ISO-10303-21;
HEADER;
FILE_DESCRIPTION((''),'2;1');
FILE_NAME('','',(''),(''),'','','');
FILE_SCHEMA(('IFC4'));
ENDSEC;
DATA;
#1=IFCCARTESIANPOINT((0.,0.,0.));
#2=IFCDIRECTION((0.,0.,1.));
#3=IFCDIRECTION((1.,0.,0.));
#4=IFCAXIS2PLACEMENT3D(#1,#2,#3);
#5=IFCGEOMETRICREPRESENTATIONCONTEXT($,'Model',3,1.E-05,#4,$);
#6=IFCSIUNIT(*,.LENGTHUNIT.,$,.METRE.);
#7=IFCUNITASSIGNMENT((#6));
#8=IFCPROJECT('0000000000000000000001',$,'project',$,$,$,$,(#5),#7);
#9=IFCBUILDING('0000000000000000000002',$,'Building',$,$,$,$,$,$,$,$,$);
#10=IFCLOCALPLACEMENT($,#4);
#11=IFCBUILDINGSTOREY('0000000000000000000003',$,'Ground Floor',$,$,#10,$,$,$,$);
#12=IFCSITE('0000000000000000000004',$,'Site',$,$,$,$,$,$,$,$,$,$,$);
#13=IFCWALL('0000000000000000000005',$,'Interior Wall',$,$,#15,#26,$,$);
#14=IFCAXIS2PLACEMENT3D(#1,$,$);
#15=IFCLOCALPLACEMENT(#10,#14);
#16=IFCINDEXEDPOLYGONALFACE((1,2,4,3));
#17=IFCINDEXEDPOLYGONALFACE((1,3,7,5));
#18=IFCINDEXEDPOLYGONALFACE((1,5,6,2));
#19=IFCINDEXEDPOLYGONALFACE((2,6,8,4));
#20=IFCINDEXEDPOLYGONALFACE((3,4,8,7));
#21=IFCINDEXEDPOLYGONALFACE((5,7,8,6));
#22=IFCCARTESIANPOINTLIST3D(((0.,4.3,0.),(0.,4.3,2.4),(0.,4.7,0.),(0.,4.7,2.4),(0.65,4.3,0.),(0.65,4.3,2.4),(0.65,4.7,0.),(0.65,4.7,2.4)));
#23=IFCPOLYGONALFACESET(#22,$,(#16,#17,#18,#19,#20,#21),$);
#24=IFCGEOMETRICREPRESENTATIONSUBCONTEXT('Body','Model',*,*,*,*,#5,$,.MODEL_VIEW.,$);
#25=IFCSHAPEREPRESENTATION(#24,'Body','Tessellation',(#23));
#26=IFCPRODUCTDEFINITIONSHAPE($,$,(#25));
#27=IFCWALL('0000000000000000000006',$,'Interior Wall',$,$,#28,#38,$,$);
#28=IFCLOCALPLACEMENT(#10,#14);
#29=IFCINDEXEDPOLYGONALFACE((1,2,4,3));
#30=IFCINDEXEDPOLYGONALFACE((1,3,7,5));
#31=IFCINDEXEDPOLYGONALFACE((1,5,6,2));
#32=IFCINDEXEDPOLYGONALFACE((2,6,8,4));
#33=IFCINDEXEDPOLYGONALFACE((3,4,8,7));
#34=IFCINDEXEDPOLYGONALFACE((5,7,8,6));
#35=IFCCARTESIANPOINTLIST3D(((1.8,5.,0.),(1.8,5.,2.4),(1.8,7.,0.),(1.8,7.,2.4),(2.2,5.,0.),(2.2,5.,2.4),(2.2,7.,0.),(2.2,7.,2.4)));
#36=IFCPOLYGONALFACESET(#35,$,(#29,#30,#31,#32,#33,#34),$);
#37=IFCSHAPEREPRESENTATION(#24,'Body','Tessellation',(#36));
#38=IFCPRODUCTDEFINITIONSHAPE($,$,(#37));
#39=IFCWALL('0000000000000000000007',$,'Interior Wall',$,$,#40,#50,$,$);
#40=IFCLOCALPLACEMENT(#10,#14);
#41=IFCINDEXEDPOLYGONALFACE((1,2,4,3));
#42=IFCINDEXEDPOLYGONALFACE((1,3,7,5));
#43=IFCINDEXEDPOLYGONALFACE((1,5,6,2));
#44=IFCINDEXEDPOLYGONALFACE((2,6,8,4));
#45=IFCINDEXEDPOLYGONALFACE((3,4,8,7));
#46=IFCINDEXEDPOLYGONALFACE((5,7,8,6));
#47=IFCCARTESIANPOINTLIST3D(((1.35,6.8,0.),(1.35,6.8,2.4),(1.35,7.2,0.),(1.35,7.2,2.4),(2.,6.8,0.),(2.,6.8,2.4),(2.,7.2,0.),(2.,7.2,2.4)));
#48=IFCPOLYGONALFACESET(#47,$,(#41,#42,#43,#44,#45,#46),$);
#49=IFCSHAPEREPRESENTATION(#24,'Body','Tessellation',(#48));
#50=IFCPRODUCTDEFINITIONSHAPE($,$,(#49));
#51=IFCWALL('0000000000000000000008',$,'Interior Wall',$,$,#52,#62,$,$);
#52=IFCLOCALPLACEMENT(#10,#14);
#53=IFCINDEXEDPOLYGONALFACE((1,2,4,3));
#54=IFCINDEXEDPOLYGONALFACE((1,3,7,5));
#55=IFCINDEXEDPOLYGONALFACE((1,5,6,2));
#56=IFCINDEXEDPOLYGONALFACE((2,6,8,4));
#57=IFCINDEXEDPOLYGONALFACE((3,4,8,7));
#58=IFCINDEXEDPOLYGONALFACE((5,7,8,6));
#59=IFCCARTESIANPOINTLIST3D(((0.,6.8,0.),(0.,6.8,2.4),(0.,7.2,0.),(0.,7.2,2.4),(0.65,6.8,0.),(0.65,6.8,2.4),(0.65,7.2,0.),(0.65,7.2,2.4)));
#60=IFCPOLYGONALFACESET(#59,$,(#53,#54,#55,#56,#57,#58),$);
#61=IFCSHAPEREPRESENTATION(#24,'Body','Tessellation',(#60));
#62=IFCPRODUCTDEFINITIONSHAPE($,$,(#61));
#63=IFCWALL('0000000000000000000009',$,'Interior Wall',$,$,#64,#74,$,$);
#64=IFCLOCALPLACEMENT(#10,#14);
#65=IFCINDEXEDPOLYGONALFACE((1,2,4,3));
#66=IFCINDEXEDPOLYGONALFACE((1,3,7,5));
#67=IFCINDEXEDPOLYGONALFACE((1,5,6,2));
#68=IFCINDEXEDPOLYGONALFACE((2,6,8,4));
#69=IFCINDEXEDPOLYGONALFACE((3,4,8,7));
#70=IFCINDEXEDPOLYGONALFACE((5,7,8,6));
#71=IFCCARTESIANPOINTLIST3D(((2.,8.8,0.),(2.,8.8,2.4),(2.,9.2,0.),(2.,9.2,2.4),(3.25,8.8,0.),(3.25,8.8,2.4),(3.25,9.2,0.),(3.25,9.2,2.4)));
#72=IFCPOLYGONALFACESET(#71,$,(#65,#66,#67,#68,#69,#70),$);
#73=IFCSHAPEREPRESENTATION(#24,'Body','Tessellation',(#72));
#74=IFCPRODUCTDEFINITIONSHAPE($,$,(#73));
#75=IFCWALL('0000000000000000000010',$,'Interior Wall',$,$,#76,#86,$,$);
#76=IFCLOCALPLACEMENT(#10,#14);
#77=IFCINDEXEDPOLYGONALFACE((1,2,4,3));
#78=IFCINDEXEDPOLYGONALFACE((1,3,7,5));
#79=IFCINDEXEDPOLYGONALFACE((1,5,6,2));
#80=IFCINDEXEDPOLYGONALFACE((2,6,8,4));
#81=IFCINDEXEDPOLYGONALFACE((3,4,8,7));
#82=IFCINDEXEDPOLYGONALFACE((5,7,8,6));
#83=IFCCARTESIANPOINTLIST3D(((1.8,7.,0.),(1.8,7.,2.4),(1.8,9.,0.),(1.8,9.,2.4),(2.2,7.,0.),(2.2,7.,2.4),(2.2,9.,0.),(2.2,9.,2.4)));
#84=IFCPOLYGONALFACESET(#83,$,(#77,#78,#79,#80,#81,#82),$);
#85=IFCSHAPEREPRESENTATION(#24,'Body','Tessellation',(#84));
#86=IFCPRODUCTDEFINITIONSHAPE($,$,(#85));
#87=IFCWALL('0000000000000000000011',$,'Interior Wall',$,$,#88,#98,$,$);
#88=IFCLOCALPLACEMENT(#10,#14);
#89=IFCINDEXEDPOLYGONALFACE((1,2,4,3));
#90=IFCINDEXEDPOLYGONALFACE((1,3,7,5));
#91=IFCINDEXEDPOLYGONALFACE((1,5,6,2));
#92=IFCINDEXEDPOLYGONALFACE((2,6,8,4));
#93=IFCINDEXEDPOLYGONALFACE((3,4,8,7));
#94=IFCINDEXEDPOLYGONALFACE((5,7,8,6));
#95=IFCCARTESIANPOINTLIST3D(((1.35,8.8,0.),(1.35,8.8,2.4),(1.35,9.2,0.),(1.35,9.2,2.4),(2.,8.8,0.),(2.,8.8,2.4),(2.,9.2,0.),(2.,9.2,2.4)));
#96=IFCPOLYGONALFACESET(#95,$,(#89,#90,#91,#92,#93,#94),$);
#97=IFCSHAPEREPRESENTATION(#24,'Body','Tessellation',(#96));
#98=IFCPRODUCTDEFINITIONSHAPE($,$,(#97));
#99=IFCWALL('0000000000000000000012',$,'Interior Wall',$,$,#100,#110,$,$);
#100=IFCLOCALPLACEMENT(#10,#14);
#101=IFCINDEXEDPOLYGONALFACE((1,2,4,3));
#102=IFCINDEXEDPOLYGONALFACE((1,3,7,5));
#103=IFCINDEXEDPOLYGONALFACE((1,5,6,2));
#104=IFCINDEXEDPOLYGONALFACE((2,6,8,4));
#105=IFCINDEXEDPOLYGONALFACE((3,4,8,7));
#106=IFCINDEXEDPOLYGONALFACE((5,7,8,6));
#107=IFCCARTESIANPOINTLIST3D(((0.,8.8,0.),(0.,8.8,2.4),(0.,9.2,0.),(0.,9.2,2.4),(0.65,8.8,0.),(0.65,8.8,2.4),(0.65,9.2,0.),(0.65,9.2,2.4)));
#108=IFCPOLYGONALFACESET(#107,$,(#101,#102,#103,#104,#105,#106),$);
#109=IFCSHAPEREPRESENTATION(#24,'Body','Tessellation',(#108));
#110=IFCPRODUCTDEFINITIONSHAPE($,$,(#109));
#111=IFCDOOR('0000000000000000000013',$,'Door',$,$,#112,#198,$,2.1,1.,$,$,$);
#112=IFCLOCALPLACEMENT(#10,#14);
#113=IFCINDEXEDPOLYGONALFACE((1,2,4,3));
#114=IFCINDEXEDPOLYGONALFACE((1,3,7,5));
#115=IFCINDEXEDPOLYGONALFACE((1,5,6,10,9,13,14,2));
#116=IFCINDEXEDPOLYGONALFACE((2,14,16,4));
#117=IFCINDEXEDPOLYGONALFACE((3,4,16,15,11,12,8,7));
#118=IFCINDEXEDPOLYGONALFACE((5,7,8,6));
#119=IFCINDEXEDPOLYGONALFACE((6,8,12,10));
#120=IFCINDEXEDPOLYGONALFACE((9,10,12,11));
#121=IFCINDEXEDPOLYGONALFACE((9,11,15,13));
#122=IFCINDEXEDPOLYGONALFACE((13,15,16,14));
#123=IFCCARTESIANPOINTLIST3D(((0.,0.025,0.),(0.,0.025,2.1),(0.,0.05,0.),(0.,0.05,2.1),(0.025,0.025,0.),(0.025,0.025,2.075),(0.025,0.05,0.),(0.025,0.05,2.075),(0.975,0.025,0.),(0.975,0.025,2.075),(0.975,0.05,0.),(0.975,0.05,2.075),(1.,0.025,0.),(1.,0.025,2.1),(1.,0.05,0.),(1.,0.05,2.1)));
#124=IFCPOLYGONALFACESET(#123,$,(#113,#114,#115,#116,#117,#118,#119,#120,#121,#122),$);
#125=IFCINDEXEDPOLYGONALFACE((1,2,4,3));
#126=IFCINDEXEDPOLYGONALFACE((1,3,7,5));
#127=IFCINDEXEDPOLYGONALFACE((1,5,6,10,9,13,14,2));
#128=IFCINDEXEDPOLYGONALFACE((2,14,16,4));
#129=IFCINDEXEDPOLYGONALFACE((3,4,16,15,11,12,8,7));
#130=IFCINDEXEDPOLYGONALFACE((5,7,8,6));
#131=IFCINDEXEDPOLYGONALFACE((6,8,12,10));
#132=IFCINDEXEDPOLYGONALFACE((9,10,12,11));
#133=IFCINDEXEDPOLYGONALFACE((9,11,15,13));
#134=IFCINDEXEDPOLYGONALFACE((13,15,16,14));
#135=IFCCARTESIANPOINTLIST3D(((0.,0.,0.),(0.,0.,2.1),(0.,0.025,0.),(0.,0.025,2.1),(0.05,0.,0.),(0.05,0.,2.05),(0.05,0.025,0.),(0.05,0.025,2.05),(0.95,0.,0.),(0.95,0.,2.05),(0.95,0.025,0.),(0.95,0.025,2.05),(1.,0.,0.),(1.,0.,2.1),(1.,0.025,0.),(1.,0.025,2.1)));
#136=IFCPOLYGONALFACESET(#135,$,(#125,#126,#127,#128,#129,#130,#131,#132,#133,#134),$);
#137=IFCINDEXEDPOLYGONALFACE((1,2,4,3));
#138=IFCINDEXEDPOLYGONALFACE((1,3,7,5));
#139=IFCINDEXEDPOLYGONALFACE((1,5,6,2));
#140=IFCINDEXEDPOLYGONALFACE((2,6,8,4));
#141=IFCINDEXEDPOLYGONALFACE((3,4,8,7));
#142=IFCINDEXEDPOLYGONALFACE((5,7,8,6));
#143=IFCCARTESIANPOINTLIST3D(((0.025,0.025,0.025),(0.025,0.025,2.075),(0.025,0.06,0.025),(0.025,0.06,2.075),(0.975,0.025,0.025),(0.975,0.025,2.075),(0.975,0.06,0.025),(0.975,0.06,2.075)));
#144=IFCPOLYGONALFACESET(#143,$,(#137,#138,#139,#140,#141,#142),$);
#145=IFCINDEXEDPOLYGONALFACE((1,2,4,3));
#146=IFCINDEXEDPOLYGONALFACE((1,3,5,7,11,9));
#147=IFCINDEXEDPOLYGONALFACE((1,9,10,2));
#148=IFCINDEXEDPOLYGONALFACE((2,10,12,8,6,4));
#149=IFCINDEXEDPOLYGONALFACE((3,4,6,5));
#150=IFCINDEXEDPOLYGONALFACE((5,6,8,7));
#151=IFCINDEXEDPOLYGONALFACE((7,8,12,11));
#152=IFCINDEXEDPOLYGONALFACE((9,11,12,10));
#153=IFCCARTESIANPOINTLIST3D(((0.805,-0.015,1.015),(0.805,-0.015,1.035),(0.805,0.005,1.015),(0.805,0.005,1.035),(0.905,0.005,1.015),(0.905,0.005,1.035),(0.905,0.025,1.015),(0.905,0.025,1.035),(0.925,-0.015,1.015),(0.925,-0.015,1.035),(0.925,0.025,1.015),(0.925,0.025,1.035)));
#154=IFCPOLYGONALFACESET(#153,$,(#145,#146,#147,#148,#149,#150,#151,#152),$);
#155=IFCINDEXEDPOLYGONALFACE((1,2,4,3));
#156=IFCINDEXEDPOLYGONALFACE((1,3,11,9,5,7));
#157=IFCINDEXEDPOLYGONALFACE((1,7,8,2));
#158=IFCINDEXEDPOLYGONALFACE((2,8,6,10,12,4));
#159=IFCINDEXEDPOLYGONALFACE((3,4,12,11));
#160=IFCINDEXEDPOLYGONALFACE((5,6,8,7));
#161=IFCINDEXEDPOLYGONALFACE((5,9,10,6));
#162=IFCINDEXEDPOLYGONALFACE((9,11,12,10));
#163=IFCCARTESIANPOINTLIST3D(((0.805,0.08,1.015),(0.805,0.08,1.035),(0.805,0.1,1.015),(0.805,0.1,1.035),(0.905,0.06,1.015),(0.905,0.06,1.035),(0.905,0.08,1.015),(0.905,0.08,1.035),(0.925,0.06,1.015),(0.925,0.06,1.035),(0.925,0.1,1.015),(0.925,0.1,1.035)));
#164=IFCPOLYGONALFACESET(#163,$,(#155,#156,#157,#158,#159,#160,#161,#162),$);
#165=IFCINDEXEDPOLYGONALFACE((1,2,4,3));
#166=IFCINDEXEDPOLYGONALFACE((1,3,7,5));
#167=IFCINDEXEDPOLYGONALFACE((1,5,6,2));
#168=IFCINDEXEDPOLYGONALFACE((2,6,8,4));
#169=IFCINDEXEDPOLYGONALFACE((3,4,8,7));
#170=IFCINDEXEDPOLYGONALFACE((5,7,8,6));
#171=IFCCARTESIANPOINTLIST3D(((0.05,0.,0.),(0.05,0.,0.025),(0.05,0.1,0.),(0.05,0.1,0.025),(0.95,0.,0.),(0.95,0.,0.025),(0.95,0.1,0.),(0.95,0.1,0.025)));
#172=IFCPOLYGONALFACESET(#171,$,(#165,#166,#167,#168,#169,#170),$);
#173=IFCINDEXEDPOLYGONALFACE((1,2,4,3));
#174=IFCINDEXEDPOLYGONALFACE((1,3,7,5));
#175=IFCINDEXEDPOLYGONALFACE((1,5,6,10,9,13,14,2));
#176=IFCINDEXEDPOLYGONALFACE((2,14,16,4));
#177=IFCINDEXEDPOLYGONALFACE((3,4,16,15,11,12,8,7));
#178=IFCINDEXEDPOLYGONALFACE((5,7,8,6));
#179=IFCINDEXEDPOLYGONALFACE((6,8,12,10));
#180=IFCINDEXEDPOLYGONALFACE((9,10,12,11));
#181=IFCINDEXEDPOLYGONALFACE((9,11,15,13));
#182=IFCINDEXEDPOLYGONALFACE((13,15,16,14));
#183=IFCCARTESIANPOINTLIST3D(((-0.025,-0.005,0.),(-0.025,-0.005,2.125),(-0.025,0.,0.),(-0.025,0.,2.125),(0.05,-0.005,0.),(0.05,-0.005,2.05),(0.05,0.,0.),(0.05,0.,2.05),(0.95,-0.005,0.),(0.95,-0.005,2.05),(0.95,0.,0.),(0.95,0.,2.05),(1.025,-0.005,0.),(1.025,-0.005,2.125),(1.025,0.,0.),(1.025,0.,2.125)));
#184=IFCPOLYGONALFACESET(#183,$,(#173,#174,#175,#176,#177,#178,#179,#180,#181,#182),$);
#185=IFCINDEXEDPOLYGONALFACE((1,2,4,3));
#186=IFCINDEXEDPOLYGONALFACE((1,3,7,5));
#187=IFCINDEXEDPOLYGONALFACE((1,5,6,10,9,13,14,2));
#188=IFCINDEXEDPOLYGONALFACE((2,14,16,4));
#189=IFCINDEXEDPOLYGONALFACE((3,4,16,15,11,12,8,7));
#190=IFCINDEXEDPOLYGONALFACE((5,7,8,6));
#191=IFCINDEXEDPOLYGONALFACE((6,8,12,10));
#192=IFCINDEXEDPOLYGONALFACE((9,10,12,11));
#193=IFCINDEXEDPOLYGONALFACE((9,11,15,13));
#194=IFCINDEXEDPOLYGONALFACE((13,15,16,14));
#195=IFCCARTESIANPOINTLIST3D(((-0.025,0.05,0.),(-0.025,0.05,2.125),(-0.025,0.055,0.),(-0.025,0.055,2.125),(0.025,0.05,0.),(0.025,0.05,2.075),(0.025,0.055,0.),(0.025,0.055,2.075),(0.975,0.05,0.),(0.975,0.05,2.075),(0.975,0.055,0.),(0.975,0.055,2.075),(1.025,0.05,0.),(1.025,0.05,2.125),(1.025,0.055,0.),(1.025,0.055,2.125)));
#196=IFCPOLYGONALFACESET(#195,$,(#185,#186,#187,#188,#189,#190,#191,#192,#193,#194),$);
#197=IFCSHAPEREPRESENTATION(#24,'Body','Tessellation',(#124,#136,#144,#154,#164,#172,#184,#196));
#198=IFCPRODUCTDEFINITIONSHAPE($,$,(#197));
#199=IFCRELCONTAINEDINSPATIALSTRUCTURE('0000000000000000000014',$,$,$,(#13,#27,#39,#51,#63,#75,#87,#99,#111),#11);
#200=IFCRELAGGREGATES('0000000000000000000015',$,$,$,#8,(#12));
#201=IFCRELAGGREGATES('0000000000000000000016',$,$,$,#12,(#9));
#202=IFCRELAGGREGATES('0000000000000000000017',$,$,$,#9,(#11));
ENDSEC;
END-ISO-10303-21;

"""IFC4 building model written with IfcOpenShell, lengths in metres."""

from ifc_helpers import new_model, si_unit, frame, origin_with_axes, place, context, subcontext, project, spatial, line, indexed_curve, outline, extrude, element, save


model = new_model("IFC4")

# Units and contexts
model_context = context("Model", 3, precision=1e-05, world=origin_with_axes())
body_context = subcontext(model_context, "Body", "Model", "MODEL_VIEW")
ifc_project = project(units=[si_unit("LENGTHUNIT", "METRE")], contexts=[model_context])

# Site, building, storey
site = spatial("IfcSite", under=ifc_project, Name="Site")
building = spatial("IfcBuilding", under=site, Name="Building")
storey_placement = place(None, origin_with_axes())
storey = spatial("IfcBuildingStorey", under=building, at=storey_placement, Name="Ground Floor")

# Walls
for number, where, z_axis, x_axis, name in (
    (1, (0.65, 4.5, 0.0), (0.0, 0.0, 1.0), (-1.0, 0.0, 0.0), "Interior Wall"),
):
    element("IfcWall", number, at=place(storey_placement, frame(where, z_axis=z_axis, x_axis=x_axis)), inside=storey, Name=name, context=body_context, shape_type="SweptSolid", body=[
        extrude(outline(indexed_curve([(0.0, 0.0), (0.0, 0.4), (0.65, 0.4), (0.65, 0.0), (0.0, 0.0)], self_intersect=False)), frame((0.0, -0.2, 0.0), z_axis=(0.0, 0.0, 1.0), x_axis=(1.0, 0.0, 0.0)), (0.0, 0.0, 1.0), 2.4),
    ])
wall_1_placement = place(storey_placement, frame((2.0, 5.0, 0.0), z_axis=(0.0, 0.0, 1.0), x_axis=(0.0, 1.0, 0.0)))
element("IfcWall", 2, at=wall_1_placement, inside=storey, Name="Interior Wall", context=body_context, shape_type="SweptSolid", body=[
    extrude(outline(indexed_curve([(0.0, 0.0), (0.0, 0.4), (2.0, 0.4), (2.0, 0.0), (0.0, 0.0)], self_intersect=False)), frame((0.0, -0.2, 0.0), z_axis=(0.0, 0.0, 1.0), x_axis=(1.0, 0.0, 0.0)), (0.0, 0.0, 1.0), 2.4),
])
for number, where, z_axis, x_axis, name in (
    (3, (2.0, 7.0, 0.0), (0.0, 0.0, 1.0), (-1.0, 0.0, 0.0), "Interior Wall"),
    (4, (0.65, 7.0, 0.0), (0.0, 0.0, 1.0), (-1.0, 0.0, 0.0), "Interior Wall"),
):
    element("IfcWall", number, at=place(storey_placement, frame(where, z_axis=z_axis, x_axis=x_axis)), inside=storey, Name=name, context=body_context, shape_type="SweptSolid", body=[
        extrude(outline(indexed_curve([(0.0, 0.0), (0.0, 0.4), (0.65, 0.4), (0.65, 0.0), (0.0, 0.0)], self_intersect=False)), frame((0.0, -0.2, 0.0), z_axis=(0.0, 0.0, 1.0), x_axis=(1.0, 0.0, 0.0)), (0.0, 0.0, 1.0), 2.4),
    ])
wall_2_placement = place(storey_placement, frame((3.25, 9.0, 0.0), z_axis=(0.0, 0.0, 1.0), x_axis=(-1.0, 0.0, 0.0)))
element("IfcWall", 5, at=wall_2_placement, inside=storey, Name="Interior Wall", context=body_context, shape_type="SweptSolid", body=[
    extrude(outline(indexed_curve([(0.0, 0.0), (0.0, 0.4), (1.25, 0.4), (1.25, 0.0), (0.0, 0.0)], self_intersect=False)), frame((0.0, -0.2, 0.0), z_axis=(0.0, 0.0, 1.0), x_axis=(1.0, 0.0, 0.0)), (0.0, 0.0, 1.0), 2.4),
])
wall_3_placement = place(storey_placement, frame((2.0, 9.0, 0.0), z_axis=(0.0, 0.0, 1.0), x_axis=(0.0, -1.0, 0.0)))
element("IfcWall", 6, at=wall_3_placement, inside=storey, Name="Interior Wall", context=body_context, shape_type="SweptSolid", body=[
    extrude(outline(indexed_curve([(0.0, 0.0), (0.0, 0.4), (2.0, 0.4), (2.0, 0.0), (0.0, 0.0)], self_intersect=False)), frame((0.0, -0.2, 0.0), z_axis=(0.0, 0.0, 1.0), x_axis=(1.0, 0.0, 0.0)), (0.0, 0.0, 1.0), 2.4),
])
for number, where, z_axis, x_axis, name in (
    (7, (2.0, 9.0, 0.0), (0.0, 0.0, 1.0), (-1.0, 0.0, 0.0), "Interior Wall"),
    (8, (0.65, 9.0, 0.0), (0.0, 0.0, 1.0), (-1.0, 0.0, 0.0), "Interior Wall"),
):
    element("IfcWall", number, at=place(storey_placement, frame(where, z_axis=z_axis, x_axis=x_axis)), inside=storey, Name=name, context=body_context, shape_type="SweptSolid", body=[
        extrude(outline(indexed_curve([(0.0, 0.0), (0.0, 0.4), (0.65, 0.4), (0.65, 0.0), (0.0, 0.0)], self_intersect=False)), frame((0.0, -0.2, 0.0), z_axis=(0.0, 0.0, 1.0), x_axis=(1.0, 0.0, 0.0)), (0.0, 0.0, 1.0), 2.4),
    ])

# Door
door_1_placement = place(storey_placement, origin_with_axes())
element("IfcDoor", 9, at=door_1_placement, inside=storey, Name="Door", OverallHeight=2.1, OverallWidth=1.0, context=body_context, shape_type="SweptSolid", body=[
    extrude(outline(indexed_curve([(0.0, 0.0), (0.0, 2.1), (1.0, 2.1), (1.0, 0.0), (0.975, 0.0), (0.975, 2.075), (0.025, 2.075), (0.025, 0.0)], segments=[line(1, 2, 3, 4, 5, 6, 7, 8, 1)])), frame((0.0, 0.025, 0.0), z_axis=(0.0, -1.0, 0.0), x_axis=(1.0, 0.0, 0.0)), (0.0, 0.0, -1.0), 0.025),
    extrude(outline(indexed_curve([(0.0, 0.0), (0.0, 2.1), (1.0, 2.1), (1.0, 0.0), (0.95, 0.0), (0.95, 2.05), (0.05, 2.05), (0.05, 0.0)], segments=[line(1, 2, 3, 4, 5, 6, 7, 8, 1)])), frame((0.0, 0.0, 0.0), z_axis=(0.0, -1.0, 0.0), x_axis=(1.0, 0.0, 0.0)), (0.0, 0.0, -1.0), 0.025),
    extrude(outline(indexed_curve([(0.0, 0.0), (0.95, 0.0), (0.95, 0.035), (0.0, 0.035)], segments=[line(1, 2, 3, 4, 1)])), frame((0.025, 0.025, 0.025), z_axis=(0.0, 0.0, 1.0), x_axis=(1.0, 0.0, 0.0)), (0.0, 0.0, 1.0), 2.05),
    extrude(outline(indexed_curve([(0.0, 0.0), (0.0, -0.04), (-0.12, -0.04), (-0.12, -0.02), (-0.02, -0.02), (-0.02, 0.0)], segments=[line(1, 2, 3, 4, 5, 6, 1)])), frame((0.925, 0.025, 1.015), z_axis=(0.0, 0.0, 1.0), x_axis=(1.0, 0.0, 0.0)), (0.0, 0.0, 1.0), 0.02),
    extrude(outline(indexed_curve([(0.0, 0.0), (0.0, 0.04), (-0.12, 0.04), (-0.12, 0.02), (-0.02, 0.02), (-0.02, 0.0)], segments=[line(1, 2, 3, 4, 5, 6, 1)])), frame((0.925, 0.06, 1.015), z_axis=(0.0, 0.0, 1.0), x_axis=(1.0, 0.0, 0.0)), (0.0, 0.0, 1.0), 0.02),
    extrude(outline(indexed_curve([(0.0, 0.0), (0.9, 0.0), (0.9, 0.1), (0.0, 0.1)], segments=[line(1, 2, 3, 4, 1)])), frame((0.05, 0.0, 0.0), z_axis=(0.0, 0.0, 1.0), x_axis=(1.0, 0.0, 0.0)), (0.0, 0.0, 1.0), 0.025),
    extrude(outline(indexed_curve([(0.0, 0.0), (0.0, 2.125), (1.05, 2.125), (1.05, 0.0), (0.975, 0.0), (0.975, 2.05), (0.075, 2.05), (0.075, 0.0)], segments=[line(1, 2, 3, 4, 5, 6, 7, 8, 1)])), frame((-0.025, -0.005, 0.0), z_axis=(0.0, -1.0, 0.0), x_axis=(1.0, 0.0, 0.0)), (0.0, 0.0, -1.0), 0.005),
    extrude(outline(indexed_curve([(0.0, 0.0), (0.0, 2.125), (1.05, 2.125), (1.05, 0.0), (1.0, 0.0), (1.0, 2.075), (0.05, 2.075), (0.05, 0.0)], segments=[line(1, 2, 3, 4, 5, 6, 7, 8, 1)])), frame((-0.025, 0.05, 0.0), z_axis=(0.0, -1.0, 0.0), x_axis=(1.0, 0.0, 0.0)), (0.0, 0.0, -1.0), 0.005),
])

save(model, "model.ifc")
